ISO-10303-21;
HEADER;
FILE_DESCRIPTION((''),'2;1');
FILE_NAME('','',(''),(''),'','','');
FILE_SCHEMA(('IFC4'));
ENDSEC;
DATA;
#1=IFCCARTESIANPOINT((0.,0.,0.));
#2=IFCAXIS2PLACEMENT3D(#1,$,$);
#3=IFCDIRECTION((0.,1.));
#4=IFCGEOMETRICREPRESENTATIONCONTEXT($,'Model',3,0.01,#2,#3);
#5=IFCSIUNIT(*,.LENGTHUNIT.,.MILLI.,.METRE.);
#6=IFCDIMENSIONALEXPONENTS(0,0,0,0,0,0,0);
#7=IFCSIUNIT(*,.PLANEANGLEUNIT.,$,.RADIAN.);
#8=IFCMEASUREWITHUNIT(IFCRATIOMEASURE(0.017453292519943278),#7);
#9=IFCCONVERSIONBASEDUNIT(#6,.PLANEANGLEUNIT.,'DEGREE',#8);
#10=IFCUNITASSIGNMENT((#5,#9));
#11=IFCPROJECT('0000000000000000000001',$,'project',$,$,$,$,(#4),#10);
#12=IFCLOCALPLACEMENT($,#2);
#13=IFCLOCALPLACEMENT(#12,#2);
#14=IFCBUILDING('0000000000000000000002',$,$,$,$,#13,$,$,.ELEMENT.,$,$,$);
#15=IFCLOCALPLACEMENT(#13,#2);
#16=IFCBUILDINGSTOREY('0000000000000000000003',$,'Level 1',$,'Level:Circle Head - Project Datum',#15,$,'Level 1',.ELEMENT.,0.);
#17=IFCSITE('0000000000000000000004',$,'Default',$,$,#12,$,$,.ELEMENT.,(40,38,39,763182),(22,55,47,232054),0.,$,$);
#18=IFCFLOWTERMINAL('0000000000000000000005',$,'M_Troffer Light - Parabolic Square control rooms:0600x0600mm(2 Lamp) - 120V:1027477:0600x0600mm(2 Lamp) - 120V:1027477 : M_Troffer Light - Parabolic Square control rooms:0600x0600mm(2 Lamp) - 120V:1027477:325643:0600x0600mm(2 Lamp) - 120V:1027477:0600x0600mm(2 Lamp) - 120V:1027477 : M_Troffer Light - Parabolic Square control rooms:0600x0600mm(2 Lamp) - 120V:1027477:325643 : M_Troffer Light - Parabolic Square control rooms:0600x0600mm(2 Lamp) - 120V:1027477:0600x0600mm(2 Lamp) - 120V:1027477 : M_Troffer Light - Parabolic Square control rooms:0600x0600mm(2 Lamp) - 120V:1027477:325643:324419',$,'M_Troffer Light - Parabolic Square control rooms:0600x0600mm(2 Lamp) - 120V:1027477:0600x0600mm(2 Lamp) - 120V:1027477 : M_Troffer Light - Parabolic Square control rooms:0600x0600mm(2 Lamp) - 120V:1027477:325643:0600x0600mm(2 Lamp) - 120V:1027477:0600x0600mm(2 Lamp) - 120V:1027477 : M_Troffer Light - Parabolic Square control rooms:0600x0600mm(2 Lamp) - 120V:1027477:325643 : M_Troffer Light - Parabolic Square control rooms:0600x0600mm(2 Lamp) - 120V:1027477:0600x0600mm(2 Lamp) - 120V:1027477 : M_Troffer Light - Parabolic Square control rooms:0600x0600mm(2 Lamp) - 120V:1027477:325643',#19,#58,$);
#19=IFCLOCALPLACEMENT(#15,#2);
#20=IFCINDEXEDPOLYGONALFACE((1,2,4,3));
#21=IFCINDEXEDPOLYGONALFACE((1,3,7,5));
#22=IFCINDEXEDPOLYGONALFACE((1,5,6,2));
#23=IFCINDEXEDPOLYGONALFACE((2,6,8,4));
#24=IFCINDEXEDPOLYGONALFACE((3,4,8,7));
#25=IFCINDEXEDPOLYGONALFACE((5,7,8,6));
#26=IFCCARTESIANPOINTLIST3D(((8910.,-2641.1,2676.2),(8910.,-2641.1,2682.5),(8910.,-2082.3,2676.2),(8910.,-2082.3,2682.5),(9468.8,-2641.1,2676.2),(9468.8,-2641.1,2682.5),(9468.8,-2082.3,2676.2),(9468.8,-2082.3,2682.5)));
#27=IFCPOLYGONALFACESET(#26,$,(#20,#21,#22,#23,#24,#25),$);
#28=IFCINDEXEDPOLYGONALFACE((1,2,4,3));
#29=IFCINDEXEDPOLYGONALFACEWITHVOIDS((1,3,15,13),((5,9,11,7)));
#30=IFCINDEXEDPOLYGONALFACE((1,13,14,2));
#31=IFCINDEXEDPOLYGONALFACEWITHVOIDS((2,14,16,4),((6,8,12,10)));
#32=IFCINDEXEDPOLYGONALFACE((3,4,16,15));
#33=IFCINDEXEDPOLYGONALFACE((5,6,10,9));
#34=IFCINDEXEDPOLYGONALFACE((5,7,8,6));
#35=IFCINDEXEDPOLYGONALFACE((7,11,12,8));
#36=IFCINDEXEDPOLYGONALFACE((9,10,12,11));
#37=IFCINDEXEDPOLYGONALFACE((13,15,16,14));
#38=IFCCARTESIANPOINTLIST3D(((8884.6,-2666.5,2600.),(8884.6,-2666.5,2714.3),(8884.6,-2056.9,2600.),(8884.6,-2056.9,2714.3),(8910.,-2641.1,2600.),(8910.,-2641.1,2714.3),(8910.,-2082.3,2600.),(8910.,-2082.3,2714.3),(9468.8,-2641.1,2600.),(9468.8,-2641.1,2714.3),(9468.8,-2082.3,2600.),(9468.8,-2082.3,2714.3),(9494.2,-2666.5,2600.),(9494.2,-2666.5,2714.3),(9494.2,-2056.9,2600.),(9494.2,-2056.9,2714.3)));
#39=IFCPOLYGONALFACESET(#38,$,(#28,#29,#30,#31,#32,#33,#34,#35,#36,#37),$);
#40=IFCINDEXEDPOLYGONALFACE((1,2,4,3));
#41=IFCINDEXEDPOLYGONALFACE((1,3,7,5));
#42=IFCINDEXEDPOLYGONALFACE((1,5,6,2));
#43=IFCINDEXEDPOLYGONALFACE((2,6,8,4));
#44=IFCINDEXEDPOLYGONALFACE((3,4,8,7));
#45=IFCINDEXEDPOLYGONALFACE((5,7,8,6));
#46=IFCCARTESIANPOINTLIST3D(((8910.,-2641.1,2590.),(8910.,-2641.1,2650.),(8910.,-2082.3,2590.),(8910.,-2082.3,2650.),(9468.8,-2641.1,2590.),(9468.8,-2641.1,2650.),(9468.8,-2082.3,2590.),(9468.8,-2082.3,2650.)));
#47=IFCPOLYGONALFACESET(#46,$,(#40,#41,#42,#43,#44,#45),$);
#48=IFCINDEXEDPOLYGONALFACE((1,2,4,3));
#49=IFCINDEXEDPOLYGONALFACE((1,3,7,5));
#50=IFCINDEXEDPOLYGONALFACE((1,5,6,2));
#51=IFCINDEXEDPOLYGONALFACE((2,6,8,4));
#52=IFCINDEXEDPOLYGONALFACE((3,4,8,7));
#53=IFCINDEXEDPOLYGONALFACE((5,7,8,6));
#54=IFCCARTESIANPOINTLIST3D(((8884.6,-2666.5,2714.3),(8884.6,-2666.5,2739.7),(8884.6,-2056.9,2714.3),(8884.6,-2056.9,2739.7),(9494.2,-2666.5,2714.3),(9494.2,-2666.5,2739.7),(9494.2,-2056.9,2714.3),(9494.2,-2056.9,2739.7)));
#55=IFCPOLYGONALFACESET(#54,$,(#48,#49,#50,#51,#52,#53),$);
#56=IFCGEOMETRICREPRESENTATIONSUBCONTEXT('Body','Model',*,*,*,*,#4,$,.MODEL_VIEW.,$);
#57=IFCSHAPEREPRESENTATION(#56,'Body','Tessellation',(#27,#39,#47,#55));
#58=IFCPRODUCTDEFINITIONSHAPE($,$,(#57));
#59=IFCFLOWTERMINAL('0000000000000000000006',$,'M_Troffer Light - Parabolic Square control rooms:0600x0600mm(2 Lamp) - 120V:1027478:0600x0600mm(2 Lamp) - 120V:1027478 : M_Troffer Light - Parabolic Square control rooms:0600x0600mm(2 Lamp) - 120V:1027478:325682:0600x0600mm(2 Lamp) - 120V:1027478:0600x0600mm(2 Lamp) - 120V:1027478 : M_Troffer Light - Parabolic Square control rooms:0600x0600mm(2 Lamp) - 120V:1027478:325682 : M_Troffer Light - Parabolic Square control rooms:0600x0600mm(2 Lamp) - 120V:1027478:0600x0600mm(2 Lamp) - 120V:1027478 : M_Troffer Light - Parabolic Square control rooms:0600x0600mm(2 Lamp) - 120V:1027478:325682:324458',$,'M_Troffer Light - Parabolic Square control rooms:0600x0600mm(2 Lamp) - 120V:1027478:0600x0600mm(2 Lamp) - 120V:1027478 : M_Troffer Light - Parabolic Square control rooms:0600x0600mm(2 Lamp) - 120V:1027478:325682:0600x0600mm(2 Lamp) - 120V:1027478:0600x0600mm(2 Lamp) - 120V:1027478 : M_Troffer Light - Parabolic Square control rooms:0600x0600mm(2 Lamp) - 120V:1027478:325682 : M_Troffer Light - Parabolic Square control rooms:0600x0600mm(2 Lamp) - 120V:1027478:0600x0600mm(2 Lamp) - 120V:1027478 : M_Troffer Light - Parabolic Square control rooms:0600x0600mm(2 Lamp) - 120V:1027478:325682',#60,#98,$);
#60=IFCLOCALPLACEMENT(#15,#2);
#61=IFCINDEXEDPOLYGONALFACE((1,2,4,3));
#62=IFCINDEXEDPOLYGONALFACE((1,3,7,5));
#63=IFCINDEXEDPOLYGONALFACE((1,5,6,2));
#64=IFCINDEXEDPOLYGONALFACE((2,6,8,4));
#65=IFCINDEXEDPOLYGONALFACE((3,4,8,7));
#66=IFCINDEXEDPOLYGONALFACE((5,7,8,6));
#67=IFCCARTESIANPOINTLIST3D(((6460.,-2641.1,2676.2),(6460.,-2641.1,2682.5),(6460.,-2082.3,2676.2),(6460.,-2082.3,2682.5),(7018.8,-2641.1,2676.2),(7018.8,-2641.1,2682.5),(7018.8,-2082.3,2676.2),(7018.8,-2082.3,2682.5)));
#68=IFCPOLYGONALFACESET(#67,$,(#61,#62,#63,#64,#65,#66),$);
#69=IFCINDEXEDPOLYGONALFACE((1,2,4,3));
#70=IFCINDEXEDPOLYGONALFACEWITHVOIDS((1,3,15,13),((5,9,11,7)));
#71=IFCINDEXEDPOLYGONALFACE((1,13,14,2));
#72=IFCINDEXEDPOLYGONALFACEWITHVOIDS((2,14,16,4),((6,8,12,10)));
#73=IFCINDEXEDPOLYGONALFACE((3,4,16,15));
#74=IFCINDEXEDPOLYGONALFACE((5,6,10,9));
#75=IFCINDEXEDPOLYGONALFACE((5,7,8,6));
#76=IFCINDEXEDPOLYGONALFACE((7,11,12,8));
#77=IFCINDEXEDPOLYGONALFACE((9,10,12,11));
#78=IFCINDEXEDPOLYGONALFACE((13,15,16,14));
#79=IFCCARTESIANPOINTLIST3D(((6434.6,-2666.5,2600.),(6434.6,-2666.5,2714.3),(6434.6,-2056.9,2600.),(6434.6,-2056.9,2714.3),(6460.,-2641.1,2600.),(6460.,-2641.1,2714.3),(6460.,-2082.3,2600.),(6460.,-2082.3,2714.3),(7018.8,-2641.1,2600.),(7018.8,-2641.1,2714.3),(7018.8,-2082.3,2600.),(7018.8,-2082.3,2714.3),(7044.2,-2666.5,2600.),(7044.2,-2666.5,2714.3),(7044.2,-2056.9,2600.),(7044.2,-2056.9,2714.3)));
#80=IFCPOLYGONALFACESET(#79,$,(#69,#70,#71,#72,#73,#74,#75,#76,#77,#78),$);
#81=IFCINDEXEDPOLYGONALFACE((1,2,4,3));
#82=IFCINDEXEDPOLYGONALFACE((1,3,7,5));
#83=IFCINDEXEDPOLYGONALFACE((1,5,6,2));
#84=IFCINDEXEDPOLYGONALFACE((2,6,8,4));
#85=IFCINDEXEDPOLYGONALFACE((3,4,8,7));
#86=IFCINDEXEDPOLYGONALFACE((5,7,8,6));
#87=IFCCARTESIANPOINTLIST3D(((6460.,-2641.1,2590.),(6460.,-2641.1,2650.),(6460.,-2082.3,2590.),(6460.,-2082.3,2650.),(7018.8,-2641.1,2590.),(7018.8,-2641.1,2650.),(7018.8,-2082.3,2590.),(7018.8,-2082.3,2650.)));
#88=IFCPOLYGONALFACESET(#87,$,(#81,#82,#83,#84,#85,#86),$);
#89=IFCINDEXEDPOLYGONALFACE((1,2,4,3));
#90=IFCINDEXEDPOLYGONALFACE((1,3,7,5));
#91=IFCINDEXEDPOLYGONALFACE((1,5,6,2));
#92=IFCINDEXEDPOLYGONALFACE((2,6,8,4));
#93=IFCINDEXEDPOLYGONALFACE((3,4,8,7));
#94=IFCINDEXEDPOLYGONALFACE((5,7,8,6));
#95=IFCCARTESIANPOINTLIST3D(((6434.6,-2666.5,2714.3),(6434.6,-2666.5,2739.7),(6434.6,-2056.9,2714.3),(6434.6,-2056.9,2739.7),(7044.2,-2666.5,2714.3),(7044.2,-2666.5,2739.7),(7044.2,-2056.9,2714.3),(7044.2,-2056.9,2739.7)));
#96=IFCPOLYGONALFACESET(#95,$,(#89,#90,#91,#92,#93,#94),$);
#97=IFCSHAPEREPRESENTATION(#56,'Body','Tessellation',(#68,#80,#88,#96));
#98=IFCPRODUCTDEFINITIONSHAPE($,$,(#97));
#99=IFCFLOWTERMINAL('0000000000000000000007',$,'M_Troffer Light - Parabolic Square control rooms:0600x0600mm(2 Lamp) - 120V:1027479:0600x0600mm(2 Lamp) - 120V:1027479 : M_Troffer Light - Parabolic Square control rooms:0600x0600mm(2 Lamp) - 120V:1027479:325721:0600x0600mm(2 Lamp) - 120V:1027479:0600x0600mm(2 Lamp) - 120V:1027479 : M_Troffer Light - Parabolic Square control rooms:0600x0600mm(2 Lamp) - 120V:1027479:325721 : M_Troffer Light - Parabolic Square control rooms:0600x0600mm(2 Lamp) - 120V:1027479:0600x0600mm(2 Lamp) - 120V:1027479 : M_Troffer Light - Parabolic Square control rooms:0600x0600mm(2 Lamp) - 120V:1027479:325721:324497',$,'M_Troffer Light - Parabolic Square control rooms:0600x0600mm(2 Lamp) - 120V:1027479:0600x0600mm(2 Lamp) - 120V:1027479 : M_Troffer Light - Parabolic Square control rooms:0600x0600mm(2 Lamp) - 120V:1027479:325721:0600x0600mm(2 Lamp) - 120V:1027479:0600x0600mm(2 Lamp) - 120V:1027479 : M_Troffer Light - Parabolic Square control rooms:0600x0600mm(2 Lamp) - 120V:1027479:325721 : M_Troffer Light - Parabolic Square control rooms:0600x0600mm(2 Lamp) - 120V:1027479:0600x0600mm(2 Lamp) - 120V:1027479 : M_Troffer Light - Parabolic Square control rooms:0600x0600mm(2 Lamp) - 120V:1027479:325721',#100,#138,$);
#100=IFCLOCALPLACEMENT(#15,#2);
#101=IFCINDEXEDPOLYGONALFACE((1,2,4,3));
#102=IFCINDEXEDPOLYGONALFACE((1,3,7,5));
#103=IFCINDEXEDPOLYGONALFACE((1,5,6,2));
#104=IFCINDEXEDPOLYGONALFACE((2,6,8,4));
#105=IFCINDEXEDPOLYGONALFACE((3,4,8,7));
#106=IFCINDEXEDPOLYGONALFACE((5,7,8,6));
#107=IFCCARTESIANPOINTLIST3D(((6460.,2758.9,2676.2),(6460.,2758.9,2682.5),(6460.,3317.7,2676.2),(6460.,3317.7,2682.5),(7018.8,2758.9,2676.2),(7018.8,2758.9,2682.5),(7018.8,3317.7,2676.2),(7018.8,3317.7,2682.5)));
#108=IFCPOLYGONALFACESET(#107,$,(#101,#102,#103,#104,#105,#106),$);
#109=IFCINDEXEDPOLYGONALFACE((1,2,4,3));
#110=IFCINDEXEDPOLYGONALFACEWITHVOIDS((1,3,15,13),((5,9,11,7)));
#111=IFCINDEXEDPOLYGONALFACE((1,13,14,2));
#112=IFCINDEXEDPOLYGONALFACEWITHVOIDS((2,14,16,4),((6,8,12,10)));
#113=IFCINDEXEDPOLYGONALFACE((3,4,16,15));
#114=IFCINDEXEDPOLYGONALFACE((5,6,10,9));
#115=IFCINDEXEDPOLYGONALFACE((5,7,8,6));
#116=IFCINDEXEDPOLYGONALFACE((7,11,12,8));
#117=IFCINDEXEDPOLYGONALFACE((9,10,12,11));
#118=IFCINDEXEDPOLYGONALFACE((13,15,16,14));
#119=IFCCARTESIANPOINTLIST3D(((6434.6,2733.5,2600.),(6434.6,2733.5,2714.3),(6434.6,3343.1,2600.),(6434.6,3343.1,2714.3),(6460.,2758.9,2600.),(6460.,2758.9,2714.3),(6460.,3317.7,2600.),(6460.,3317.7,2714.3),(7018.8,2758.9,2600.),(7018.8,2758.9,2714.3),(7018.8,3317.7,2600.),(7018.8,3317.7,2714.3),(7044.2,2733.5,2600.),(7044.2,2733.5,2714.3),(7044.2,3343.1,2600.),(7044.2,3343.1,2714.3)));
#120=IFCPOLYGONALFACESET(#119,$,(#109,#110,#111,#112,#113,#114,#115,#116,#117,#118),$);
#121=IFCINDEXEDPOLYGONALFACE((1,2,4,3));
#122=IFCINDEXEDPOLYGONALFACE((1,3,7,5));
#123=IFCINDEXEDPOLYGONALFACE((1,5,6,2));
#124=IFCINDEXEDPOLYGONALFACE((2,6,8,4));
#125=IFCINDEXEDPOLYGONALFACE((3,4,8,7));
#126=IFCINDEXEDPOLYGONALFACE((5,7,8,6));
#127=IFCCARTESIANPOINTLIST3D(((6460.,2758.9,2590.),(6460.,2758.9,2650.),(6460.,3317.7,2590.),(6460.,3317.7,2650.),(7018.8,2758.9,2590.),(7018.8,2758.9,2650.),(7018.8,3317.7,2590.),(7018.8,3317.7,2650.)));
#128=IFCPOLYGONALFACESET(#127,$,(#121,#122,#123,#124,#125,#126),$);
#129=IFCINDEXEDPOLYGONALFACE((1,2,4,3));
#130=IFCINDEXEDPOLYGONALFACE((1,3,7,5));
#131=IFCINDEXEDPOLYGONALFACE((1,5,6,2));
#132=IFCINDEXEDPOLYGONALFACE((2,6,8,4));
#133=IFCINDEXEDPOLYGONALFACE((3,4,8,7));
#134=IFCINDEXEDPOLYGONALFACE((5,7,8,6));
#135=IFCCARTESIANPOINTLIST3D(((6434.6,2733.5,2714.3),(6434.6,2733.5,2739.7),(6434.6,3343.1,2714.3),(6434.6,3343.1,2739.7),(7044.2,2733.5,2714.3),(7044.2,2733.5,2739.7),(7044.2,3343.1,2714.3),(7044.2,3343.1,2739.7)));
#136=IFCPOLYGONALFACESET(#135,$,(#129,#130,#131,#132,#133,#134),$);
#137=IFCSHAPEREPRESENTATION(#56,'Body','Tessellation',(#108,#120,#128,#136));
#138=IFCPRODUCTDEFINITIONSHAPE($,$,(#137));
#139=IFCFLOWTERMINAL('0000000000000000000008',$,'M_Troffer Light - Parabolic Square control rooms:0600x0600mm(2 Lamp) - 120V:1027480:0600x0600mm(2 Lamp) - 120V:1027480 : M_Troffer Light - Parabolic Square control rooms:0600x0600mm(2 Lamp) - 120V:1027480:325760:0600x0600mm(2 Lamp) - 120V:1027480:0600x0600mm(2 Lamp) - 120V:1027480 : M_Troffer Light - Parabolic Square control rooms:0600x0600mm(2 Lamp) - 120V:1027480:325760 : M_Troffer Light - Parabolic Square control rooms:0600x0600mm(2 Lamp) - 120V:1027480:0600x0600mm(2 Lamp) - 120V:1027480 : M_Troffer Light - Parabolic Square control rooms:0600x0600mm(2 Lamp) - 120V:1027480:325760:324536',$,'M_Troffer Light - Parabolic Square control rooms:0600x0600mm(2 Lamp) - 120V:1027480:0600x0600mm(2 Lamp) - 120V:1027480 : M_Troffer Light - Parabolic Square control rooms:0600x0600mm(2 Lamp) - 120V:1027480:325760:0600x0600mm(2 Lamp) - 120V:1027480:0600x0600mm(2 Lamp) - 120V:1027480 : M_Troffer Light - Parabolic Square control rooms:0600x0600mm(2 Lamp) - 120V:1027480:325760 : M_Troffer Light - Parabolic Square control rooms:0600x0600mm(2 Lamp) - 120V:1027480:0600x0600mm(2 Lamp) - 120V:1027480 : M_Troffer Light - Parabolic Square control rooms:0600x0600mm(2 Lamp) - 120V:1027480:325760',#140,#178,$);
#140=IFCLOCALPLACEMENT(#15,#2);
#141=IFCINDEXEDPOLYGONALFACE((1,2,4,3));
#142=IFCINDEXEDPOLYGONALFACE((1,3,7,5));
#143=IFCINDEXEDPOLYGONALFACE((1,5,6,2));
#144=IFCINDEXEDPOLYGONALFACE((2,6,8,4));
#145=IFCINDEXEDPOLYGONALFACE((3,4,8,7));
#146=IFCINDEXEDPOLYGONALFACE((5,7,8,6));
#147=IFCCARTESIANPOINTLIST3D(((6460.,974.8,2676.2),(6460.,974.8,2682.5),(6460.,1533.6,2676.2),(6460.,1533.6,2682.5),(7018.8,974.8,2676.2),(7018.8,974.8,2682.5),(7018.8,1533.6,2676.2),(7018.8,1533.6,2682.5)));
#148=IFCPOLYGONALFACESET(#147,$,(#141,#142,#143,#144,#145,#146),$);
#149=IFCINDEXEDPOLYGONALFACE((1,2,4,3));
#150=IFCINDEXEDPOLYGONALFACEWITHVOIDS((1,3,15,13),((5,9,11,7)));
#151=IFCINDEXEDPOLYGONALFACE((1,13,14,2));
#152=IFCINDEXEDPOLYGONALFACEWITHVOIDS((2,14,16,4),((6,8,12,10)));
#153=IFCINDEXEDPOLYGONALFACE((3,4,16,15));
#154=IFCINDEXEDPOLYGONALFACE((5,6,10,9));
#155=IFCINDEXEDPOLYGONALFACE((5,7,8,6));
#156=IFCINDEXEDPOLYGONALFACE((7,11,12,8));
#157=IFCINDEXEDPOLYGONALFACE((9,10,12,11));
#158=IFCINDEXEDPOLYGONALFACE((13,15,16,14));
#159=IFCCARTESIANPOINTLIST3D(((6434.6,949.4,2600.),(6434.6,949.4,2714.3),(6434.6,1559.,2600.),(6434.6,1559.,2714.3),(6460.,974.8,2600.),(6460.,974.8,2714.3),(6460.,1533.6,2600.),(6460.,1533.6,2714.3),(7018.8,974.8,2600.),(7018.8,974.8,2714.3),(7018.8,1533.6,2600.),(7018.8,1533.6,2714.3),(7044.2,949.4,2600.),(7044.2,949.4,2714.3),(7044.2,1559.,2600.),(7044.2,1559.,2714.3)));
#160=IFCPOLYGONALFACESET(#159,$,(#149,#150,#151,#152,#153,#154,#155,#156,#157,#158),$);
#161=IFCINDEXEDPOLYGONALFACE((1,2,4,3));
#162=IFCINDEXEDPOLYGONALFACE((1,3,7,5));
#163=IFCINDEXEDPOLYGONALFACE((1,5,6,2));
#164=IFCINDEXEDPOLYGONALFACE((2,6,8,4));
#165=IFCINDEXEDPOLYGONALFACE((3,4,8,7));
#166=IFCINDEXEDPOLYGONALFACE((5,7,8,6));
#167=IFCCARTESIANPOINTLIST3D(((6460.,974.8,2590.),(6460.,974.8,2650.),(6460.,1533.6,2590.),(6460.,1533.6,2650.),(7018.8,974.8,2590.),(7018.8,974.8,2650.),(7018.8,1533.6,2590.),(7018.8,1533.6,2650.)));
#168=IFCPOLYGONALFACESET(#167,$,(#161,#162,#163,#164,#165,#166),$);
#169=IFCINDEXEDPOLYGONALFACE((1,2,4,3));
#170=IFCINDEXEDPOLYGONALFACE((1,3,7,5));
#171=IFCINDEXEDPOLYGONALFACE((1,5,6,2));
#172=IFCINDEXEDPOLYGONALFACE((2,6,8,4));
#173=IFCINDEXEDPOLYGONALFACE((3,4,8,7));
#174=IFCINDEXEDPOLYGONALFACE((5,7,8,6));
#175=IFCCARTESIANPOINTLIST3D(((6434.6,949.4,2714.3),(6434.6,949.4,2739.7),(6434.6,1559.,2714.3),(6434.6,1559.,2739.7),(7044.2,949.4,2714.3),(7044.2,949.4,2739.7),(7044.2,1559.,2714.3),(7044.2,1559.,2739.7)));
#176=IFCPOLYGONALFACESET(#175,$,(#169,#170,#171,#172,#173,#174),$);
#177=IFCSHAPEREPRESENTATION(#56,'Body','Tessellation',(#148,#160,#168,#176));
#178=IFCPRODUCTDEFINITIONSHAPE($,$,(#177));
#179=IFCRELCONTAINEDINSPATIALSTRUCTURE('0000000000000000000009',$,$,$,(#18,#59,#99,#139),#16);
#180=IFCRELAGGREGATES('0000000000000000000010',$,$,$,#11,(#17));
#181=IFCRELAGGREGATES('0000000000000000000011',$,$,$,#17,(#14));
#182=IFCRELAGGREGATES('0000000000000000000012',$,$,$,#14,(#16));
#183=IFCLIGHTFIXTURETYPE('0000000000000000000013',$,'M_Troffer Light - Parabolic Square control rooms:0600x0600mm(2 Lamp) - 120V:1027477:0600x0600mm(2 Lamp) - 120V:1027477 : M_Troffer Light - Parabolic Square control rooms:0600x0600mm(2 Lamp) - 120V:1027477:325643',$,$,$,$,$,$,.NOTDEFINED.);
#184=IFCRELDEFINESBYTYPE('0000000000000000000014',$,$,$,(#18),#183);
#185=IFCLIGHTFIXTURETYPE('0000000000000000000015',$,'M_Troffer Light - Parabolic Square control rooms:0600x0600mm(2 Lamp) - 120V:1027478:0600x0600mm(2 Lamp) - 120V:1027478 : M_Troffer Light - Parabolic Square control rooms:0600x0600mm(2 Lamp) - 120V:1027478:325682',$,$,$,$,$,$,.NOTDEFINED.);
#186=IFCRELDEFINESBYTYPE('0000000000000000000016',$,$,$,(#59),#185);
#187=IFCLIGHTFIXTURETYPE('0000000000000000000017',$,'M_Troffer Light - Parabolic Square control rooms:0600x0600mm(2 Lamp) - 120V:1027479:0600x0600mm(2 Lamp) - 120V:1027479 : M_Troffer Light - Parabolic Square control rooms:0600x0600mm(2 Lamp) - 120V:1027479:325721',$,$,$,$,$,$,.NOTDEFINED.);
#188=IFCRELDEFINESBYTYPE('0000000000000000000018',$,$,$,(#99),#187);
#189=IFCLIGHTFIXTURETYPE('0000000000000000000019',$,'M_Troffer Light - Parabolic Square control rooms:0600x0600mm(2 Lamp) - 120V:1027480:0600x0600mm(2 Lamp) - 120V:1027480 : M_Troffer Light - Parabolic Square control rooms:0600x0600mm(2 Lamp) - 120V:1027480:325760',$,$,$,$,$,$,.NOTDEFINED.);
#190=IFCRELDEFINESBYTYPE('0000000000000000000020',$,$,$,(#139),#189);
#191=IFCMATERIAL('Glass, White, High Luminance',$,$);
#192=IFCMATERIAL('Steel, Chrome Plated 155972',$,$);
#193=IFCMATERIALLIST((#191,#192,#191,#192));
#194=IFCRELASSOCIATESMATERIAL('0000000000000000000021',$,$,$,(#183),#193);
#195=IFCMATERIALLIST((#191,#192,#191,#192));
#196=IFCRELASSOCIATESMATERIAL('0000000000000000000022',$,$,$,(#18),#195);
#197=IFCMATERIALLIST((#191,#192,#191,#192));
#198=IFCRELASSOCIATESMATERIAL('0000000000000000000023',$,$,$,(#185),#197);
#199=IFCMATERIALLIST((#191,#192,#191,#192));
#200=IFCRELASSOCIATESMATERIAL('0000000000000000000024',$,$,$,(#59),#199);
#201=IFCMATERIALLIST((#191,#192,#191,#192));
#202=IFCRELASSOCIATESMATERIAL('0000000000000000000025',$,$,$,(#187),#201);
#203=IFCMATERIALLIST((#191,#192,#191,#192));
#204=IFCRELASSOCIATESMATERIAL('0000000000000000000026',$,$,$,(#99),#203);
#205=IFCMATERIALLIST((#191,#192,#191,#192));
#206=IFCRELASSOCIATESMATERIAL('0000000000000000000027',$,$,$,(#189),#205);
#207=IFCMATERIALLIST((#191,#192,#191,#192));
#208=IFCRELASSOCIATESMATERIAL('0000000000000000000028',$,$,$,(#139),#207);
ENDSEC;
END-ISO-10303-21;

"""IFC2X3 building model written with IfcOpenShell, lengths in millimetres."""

from ifc_helpers import new_model, entity, si_unit, converted_unit, direction, frame, frame_2d, origin, origin_2d_with_axis, place, context, subcontext, project, spatial, polyline, rectangle, outline, extrude, source, transform, mapped, material, material_list, type_object, type_shapes, element, save


model = new_model("IFC2X3")

# Units and contexts
model_context = context("Model", 3, precision=0.01, world=origin(), true_north=direction((0.0, 1.0)))
body_context = subcontext(model_context, "Body", "Model", "MODEL_VIEW")
ifc_project = project(units=[si_unit("LENGTHUNIT", "METRE", prefix="MILLI"), converted_unit("PLANEANGLEUNIT", "DEGREE", entity("IfcRatioMeasure", 0.017453292519943278), si_unit("PLANEANGLEUNIT", "RADIAN"), dimensions=[0, 0, 0, 0, 0, 0, 0])], contexts=[model_context])

# Site, building, storey
site_placement = place(None, origin())
site = spatial("IfcSite", under=ifc_project, at=site_placement, Name="Default", CompositionType="ELEMENT", RefLatitude=(40, 38, 39, 763182), RefLongitude=(22, 55, 47, 232054), RefElevation=0.0)
building_placement = place(site_placement, origin())
building = spatial("IfcBuilding", under=site, at=building_placement, CompositionType="ELEMENT")
storey_placement = place(building_placement, origin())
storey = spatial("IfcBuildingStorey", under=building, at=storey_placement, Name="Level 1", ObjectType="Level:Circle Head - Project Datum", LongName="Level 1", CompositionType="ELEMENT", Elevation=0.0)

# Flow terminals
ifc_material_1 = material(Name="Glass, White, High Luminance")
ifc_material_2 = material(Name="Steel, Chrome Plated 155972")
ifc_material_list_1 = material_list([ifc_material_1, ifc_material_2, ifc_material_1, ifc_material_2])
ifc_material_list_2 = material_list([ifc_material_1, ifc_material_2, ifc_material_1, ifc_material_2])
light_fixture_type_1 = type_object("IfcLightFixtureType", Name="M_Troffer Light - Parabolic Square control rooms:0600x0600mm(2 Lamp) - 120V:1027477:0600x0600mm(2 Lamp) - 120V:1027477 : M_Troffer Light - Parabolic Square control rooms:0600x0600mm(2 Lamp) - 120V:1027477:325643", PredefinedType="NOTDEFINED", material=ifc_material_list_2)
shared_shape_1 = source(origin(), body_context, "Body", "SweptSolid", [
    extrude(rectangle(XDim=558.8, YDim=558.8, at=frame_2d((0.0, 0.0), x_axis=(1.0, 0.0))), frame((9189.4, -2361.7, 2676.2), z_axis=(0.0, 0.0, 1.0), x_axis=(0.0, 1.0, 0.0)), (0.0, 0.0, 1.0), 6.4),
    extrude(outline(polyline([(-304.8, -304.8), (304.8, -304.8), (304.8, 304.8), (-304.8, 304.8), (-304.8, -304.8)]), holes=[polyline([(279.4, 279.4), (279.4, -279.4), (-279.4, -279.4), (-279.4, 279.4), (279.4, 279.4)])]), frame((9189.4, -2361.7, 2600.0), z_axis=(0.0, 0.0, 1.0), x_axis=(0.0, -1.0, 0.0)), (0.0, 0.0, 1.0), 114.3),
    extrude(rectangle(XDim=558.8, YDim=558.8, at=frame_2d((0.0, 0.0), x_axis=(1.0, 0.0))), frame((9189.4, -2361.7, 2590.0), z_axis=(0.0, 0.0, 1.0), x_axis=(0.0, 1.0, 0.0)), (0.0, 0.0, 1.0), 60.0),
    extrude(rectangle(XDim=609.6, YDim=609.6, at=origin_2d_with_axis()), frame((9189.4, -2361.7, 2714.3), z_axis=(0.0, 0.0, 1.0), x_axis=(0.0, 1.0, 0.0)), (0.0, 0.0, 1.0), 25.4),
])
type_shapes(light_fixture_type_1, [shared_shape_1])
flow_terminal_1_placement = place(storey_placement, origin())
element("IfcFlowTerminal", 1, at=flow_terminal_1_placement, inside=storey, type_object=light_fixture_type_1, material=ifc_material_list_1, Name="M_Troffer Light - Parabolic Square control rooms:0600x0600mm(2 Lamp) - 120V:1027477:0600x0600mm(2 Lamp) - 120V:1027477 : M_Troffer Light - Parabolic Square control rooms:0600x0600mm(2 Lamp) - 120V:1027477:325643:0600x0600mm(2 Lamp) - 120V:1027477:0600x0600mm(2 Lamp) - 120V:1027477 : M_Troffer Light - Parabolic Square control rooms:0600x0600mm(2 Lamp) - 120V:1027477:325643 : M_Troffer Light - Parabolic Square control rooms:0600x0600mm(2 Lamp) - 120V:1027477:0600x0600mm(2 Lamp) - 120V:1027477 : M_Troffer Light - Parabolic Square control rooms:0600x0600mm(2 Lamp) - 120V:1027477:325643:324419", ObjectType="M_Troffer Light - Parabolic Square control rooms:0600x0600mm(2 Lamp) - 120V:1027477:0600x0600mm(2 Lamp) - 120V:1027477 : M_Troffer Light - Parabolic Square control rooms:0600x0600mm(2 Lamp) - 120V:1027477:325643:0600x0600mm(2 Lamp) - 120V:1027477:0600x0600mm(2 Lamp) - 120V:1027477 : M_Troffer Light - Parabolic Square control rooms:0600x0600mm(2 Lamp) - 120V:1027477:325643 : M_Troffer Light - Parabolic Square control rooms:0600x0600mm(2 Lamp) - 120V:1027477:0600x0600mm(2 Lamp) - 120V:1027477 : M_Troffer Light - Parabolic Square control rooms:0600x0600mm(2 Lamp) - 120V:1027477:325643", context=body_context, shape_type="MappedRepresentation", body=[
    mapped(shared_shape_1, transform((0.0, 0.0, 0.0), scale=1.0)),
])
ifc_material_list_3 = material_list([ifc_material_1, ifc_material_2, ifc_material_1, ifc_material_2])
ifc_material_list_4 = material_list([ifc_material_1, ifc_material_2, ifc_material_1, ifc_material_2])
light_fixture_type_2 = type_object("IfcLightFixtureType", Name="M_Troffer Light - Parabolic Square control rooms:0600x0600mm(2 Lamp) - 120V:1027478:0600x0600mm(2 Lamp) - 120V:1027478 : M_Troffer Light - Parabolic Square control rooms:0600x0600mm(2 Lamp) - 120V:1027478:325682", PredefinedType="NOTDEFINED", material=ifc_material_list_4)
shared_shape_2 = source(origin(), body_context, "Body", "SweptSolid", [
    extrude(rectangle(XDim=558.8, YDim=558.8, at=frame_2d((0.0, 0.0), x_axis=(1.0, 0.0))), frame((6739.4, -2361.7, 2676.2), z_axis=(0.0, 0.0, 1.0), x_axis=(0.0, 1.0, 0.0)), (0.0, 0.0, 1.0), 6.4),
    extrude(outline(polyline([(-304.8, -304.8), (304.8, -304.8), (304.8, 304.8), (-304.8, 304.8), (-304.8, -304.8)]), holes=[polyline([(279.4, 279.4), (279.4, -279.4), (-279.4, -279.4), (-279.4, 279.4), (279.4, 279.4)])]), frame((6739.4, -2361.7, 2600.0), z_axis=(0.0, 0.0, 1.0), x_axis=(0.0, -1.0, 0.0)), (0.0, 0.0, 1.0), 114.3),
    extrude(rectangle(XDim=558.8, YDim=558.8, at=frame_2d((0.0, 0.0), x_axis=(1.0, 0.0))), frame((6739.4, -2361.7, 2590.0), z_axis=(0.0, 0.0, 1.0), x_axis=(0.0, 1.0, 0.0)), (0.0, 0.0, 1.0), 60.0),
    extrude(rectangle(XDim=609.6, YDim=609.6, at=origin_2d_with_axis()), frame((6739.4, -2361.7, 2714.3), z_axis=(0.0, 0.0, 1.0), x_axis=(0.0, 1.0, 0.0)), (0.0, 0.0, 1.0), 25.4),
])
type_shapes(light_fixture_type_2, [shared_shape_2])
flow_terminal_2_placement = place(storey_placement, origin())
element("IfcFlowTerminal", 2, at=flow_terminal_2_placement, inside=storey, type_object=light_fixture_type_2, material=ifc_material_list_3, Name="M_Troffer Light - Parabolic Square control rooms:0600x0600mm(2 Lamp) - 120V:1027478:0600x0600mm(2 Lamp) - 120V:1027478 : M_Troffer Light - Parabolic Square control rooms:0600x0600mm(2 Lamp) - 120V:1027478:325682:0600x0600mm(2 Lamp) - 120V:1027478:0600x0600mm(2 Lamp) - 120V:1027478 : M_Troffer Light - Parabolic Square control rooms:0600x0600mm(2 Lamp) - 120V:1027478:325682 : M_Troffer Light - Parabolic Square control rooms:0600x0600mm(2 Lamp) - 120V:1027478:0600x0600mm(2 Lamp) - 120V:1027478 : M_Troffer Light - Parabolic Square control rooms:0600x0600mm(2 Lamp) - 120V:1027478:325682:324458", ObjectType="M_Troffer Light - Parabolic Square control rooms:0600x0600mm(2 Lamp) - 120V:1027478:0600x0600mm(2 Lamp) - 120V:1027478 : M_Troffer Light - Parabolic Square control rooms:0600x0600mm(2 Lamp) - 120V:1027478:325682:0600x0600mm(2 Lamp) - 120V:1027478:0600x0600mm(2 Lamp) - 120V:1027478 : M_Troffer Light - Parabolic Square control rooms:0600x0600mm(2 Lamp) - 120V:1027478:325682 : M_Troffer Light - Parabolic Square control rooms:0600x0600mm(2 Lamp) - 120V:1027478:0600x0600mm(2 Lamp) - 120V:1027478 : M_Troffer Light - Parabolic Square control rooms:0600x0600mm(2 Lamp) - 120V:1027478:325682", context=body_context, shape_type="MappedRepresentation", body=[
    mapped(shared_shape_2, transform((0.0, 0.0, 0.0), scale=1.0)),
])
ifc_material_list_5 = material_list([ifc_material_1, ifc_material_2, ifc_material_1, ifc_material_2])
ifc_material_list_6 = material_list([ifc_material_1, ifc_material_2, ifc_material_1, ifc_material_2])
light_fixture_type_3 = type_object("IfcLightFixtureType", Name="M_Troffer Light - Parabolic Square control rooms:0600x0600mm(2 Lamp) - 120V:1027479:0600x0600mm(2 Lamp) - 120V:1027479 : M_Troffer Light - Parabolic Square control rooms:0600x0600mm(2 Lamp) - 120V:1027479:325721", PredefinedType="NOTDEFINED", material=ifc_material_list_6)
shared_shape_3 = source(origin(), body_context, "Body", "SweptSolid", [
    extrude(rectangle(XDim=558.8, YDim=558.8, at=frame_2d((0.0, 0.0), x_axis=(1.0, 0.0))), frame((6739.4, 3038.3, 2676.2), z_axis=(0.0, 0.0, 1.0), x_axis=(0.0, 1.0, 0.0)), (0.0, 0.0, 1.0), 6.4),
    extrude(outline(polyline([(-304.8, -304.8), (304.8, -304.8), (304.8, 304.8), (-304.8, 304.8), (-304.8, -304.8)]), holes=[polyline([(279.4, 279.4), (279.4, -279.4), (-279.4, -279.4), (-279.4, 279.4), (279.4, 279.4)])]), frame((6739.4, 3038.3, 2600.0), z_axis=(0.0, 0.0, 1.0), x_axis=(0.0, -1.0, 0.0)), (0.0, 0.0, 1.0), 114.3),
    extrude(rectangle(XDim=558.8, YDim=558.8, at=frame_2d((0.0, 0.0), x_axis=(1.0, 0.0))), frame((6739.4, 3038.3, 2590.0), z_axis=(0.0, 0.0, 1.0), x_axis=(0.0, 1.0, 0.0)), (0.0, 0.0, 1.0), 60.0),
    extrude(rectangle(XDim=609.6, YDim=609.6, at=frame_2d((0.0, 0.0), x_axis=(1.0, 0.0))), frame((6739.4, 3038.3, 2714.3), z_axis=(0.0, 0.0, 1.0), x_axis=(0.0, 1.0, 0.0)), (0.0, 0.0, 1.0), 25.4),
])
type_shapes(light_fixture_type_3, [shared_shape_3])
flow_terminal_3_placement = place(storey_placement, origin())
element("IfcFlowTerminal", 3, at=flow_terminal_3_placement, inside=storey, type_object=light_fixture_type_3, material=ifc_material_list_5, Name="M_Troffer Light - Parabolic Square control rooms:0600x0600mm(2 Lamp) - 120V:1027479:0600x0600mm(2 Lamp) - 120V:1027479 : M_Troffer Light - Parabolic Square control rooms:0600x0600mm(2 Lamp) - 120V:1027479:325721:0600x0600mm(2 Lamp) - 120V:1027479:0600x0600mm(2 Lamp) - 120V:1027479 : M_Troffer Light - Parabolic Square control rooms:0600x0600mm(2 Lamp) - 120V:1027479:325721 : M_Troffer Light - Parabolic Square control rooms:0600x0600mm(2 Lamp) - 120V:1027479:0600x0600mm(2 Lamp) - 120V:1027479 : M_Troffer Light - Parabolic Square control rooms:0600x0600mm(2 Lamp) - 120V:1027479:325721:324497", ObjectType="M_Troffer Light - Parabolic Square control rooms:0600x0600mm(2 Lamp) - 120V:1027479:0600x0600mm(2 Lamp) - 120V:1027479 : M_Troffer Light - Parabolic Square control rooms:0600x0600mm(2 Lamp) - 120V:1027479:325721:0600x0600mm(2 Lamp) - 120V:1027479:0600x0600mm(2 Lamp) - 120V:1027479 : M_Troffer Light - Parabolic Square control rooms:0600x0600mm(2 Lamp) - 120V:1027479:325721 : M_Troffer Light - Parabolic Square control rooms:0600x0600mm(2 Lamp) - 120V:1027479:0600x0600mm(2 Lamp) - 120V:1027479 : M_Troffer Light - Parabolic Square control rooms:0600x0600mm(2 Lamp) - 120V:1027479:325721", context=body_context, shape_type="MappedRepresentation", body=[
    mapped(shared_shape_3, transform((0.0, 0.0, 0.0), scale=1.0)),
])
ifc_material_list_7 = material_list([ifc_material_1, ifc_material_2, ifc_material_1, ifc_material_2])
ifc_material_list_8 = material_list([ifc_material_1, ifc_material_2, ifc_material_1, ifc_material_2])
light_fixture_type_4 = type_object("IfcLightFixtureType", Name="M_Troffer Light - Parabolic Square control rooms:0600x0600mm(2 Lamp) - 120V:1027480:0600x0600mm(2 Lamp) - 120V:1027480 : M_Troffer Light - Parabolic Square control rooms:0600x0600mm(2 Lamp) - 120V:1027480:325760", PredefinedType="NOTDEFINED", material=ifc_material_list_8)
shared_shape_4 = source(origin(), body_context, "Body", "SweptSolid", [
    extrude(rectangle(XDim=558.8, YDim=558.8, at=frame_2d((0.0, 0.0), x_axis=(1.0, 0.0))), frame((6739.4, 1254.2, 2676.2), z_axis=(0.0, 0.0, 1.0), x_axis=(0.0, 1.0, 0.0)), (0.0, 0.0, 1.0), 6.4),
    extrude(outline(polyline([(-304.8, -304.8), (304.8, -304.8), (304.8, 304.8), (-304.8, 304.8), (-304.8, -304.8)]), holes=[polyline([(279.4, 279.4), (279.4, -279.4), (-279.4, -279.4), (-279.4, 279.4), (279.4, 279.4)])]), frame((6739.4, 1254.2, 2600.0), z_axis=(0.0, 0.0, 1.0), x_axis=(0.0, -1.0, 0.0)), (0.0, 0.0, 1.0), 114.3),
    extrude(rectangle(XDim=558.8, YDim=558.8, at=frame_2d((0.0, 0.0), x_axis=(1.0, 0.0))), frame((6739.4, 1254.2, 2590.0), z_axis=(0.0, 0.0, 1.0), x_axis=(0.0, 1.0, 0.0)), (0.0, 0.0, 1.0), 60.0),
    extrude(rectangle(XDim=609.6, YDim=609.6, at=frame_2d((0.0, 0.0), x_axis=(1.0, 0.0))), frame((6739.4, 1254.2, 2714.3), z_axis=(0.0, 0.0, 1.0), x_axis=(0.0, 1.0, 0.0)), (0.0, 0.0, 1.0), 25.4),
])
type_shapes(light_fixture_type_4, [shared_shape_4])
flow_terminal_4_placement = place(storey_placement, origin())
element("IfcFlowTerminal", 4, at=flow_terminal_4_placement, inside=storey, type_object=light_fixture_type_4, material=ifc_material_list_7, Name="M_Troffer Light - Parabolic Square control rooms:0600x0600mm(2 Lamp) - 120V:1027480:0600x0600mm(2 Lamp) - 120V:1027480 : M_Troffer Light - Parabolic Square control rooms:0600x0600mm(2 Lamp) - 120V:1027480:325760:0600x0600mm(2 Lamp) - 120V:1027480:0600x0600mm(2 Lamp) - 120V:1027480 : M_Troffer Light - Parabolic Square control rooms:0600x0600mm(2 Lamp) - 120V:1027480:325760 : M_Troffer Light - Parabolic Square control rooms:0600x0600mm(2 Lamp) - 120V:1027480:0600x0600mm(2 Lamp) - 120V:1027480 : M_Troffer Light - Parabolic Square control rooms:0600x0600mm(2 Lamp) - 120V:1027480:325760:324536", ObjectType="M_Troffer Light - Parabolic Square control rooms:0600x0600mm(2 Lamp) - 120V:1027480:0600x0600mm(2 Lamp) - 120V:1027480 : M_Troffer Light - Parabolic Square control rooms:0600x0600mm(2 Lamp) - 120V:1027480:325760:0600x0600mm(2 Lamp) - 120V:1027480:0600x0600mm(2 Lamp) - 120V:1027480 : M_Troffer Light - Parabolic Square control rooms:0600x0600mm(2 Lamp) - 120V:1027480:325760 : M_Troffer Light - Parabolic Square control rooms:0600x0600mm(2 Lamp) - 120V:1027480:0600x0600mm(2 Lamp) - 120V:1027480 : M_Troffer Light - Parabolic Square control rooms:0600x0600mm(2 Lamp) - 120V:1027480:325760", context=body_context, shape_type="MappedRepresentation", body=[
    mapped(shared_shape_4, transform((0.0, 0.0, 0.0), scale=1.0)),
])

save(model, "model.ifc")
